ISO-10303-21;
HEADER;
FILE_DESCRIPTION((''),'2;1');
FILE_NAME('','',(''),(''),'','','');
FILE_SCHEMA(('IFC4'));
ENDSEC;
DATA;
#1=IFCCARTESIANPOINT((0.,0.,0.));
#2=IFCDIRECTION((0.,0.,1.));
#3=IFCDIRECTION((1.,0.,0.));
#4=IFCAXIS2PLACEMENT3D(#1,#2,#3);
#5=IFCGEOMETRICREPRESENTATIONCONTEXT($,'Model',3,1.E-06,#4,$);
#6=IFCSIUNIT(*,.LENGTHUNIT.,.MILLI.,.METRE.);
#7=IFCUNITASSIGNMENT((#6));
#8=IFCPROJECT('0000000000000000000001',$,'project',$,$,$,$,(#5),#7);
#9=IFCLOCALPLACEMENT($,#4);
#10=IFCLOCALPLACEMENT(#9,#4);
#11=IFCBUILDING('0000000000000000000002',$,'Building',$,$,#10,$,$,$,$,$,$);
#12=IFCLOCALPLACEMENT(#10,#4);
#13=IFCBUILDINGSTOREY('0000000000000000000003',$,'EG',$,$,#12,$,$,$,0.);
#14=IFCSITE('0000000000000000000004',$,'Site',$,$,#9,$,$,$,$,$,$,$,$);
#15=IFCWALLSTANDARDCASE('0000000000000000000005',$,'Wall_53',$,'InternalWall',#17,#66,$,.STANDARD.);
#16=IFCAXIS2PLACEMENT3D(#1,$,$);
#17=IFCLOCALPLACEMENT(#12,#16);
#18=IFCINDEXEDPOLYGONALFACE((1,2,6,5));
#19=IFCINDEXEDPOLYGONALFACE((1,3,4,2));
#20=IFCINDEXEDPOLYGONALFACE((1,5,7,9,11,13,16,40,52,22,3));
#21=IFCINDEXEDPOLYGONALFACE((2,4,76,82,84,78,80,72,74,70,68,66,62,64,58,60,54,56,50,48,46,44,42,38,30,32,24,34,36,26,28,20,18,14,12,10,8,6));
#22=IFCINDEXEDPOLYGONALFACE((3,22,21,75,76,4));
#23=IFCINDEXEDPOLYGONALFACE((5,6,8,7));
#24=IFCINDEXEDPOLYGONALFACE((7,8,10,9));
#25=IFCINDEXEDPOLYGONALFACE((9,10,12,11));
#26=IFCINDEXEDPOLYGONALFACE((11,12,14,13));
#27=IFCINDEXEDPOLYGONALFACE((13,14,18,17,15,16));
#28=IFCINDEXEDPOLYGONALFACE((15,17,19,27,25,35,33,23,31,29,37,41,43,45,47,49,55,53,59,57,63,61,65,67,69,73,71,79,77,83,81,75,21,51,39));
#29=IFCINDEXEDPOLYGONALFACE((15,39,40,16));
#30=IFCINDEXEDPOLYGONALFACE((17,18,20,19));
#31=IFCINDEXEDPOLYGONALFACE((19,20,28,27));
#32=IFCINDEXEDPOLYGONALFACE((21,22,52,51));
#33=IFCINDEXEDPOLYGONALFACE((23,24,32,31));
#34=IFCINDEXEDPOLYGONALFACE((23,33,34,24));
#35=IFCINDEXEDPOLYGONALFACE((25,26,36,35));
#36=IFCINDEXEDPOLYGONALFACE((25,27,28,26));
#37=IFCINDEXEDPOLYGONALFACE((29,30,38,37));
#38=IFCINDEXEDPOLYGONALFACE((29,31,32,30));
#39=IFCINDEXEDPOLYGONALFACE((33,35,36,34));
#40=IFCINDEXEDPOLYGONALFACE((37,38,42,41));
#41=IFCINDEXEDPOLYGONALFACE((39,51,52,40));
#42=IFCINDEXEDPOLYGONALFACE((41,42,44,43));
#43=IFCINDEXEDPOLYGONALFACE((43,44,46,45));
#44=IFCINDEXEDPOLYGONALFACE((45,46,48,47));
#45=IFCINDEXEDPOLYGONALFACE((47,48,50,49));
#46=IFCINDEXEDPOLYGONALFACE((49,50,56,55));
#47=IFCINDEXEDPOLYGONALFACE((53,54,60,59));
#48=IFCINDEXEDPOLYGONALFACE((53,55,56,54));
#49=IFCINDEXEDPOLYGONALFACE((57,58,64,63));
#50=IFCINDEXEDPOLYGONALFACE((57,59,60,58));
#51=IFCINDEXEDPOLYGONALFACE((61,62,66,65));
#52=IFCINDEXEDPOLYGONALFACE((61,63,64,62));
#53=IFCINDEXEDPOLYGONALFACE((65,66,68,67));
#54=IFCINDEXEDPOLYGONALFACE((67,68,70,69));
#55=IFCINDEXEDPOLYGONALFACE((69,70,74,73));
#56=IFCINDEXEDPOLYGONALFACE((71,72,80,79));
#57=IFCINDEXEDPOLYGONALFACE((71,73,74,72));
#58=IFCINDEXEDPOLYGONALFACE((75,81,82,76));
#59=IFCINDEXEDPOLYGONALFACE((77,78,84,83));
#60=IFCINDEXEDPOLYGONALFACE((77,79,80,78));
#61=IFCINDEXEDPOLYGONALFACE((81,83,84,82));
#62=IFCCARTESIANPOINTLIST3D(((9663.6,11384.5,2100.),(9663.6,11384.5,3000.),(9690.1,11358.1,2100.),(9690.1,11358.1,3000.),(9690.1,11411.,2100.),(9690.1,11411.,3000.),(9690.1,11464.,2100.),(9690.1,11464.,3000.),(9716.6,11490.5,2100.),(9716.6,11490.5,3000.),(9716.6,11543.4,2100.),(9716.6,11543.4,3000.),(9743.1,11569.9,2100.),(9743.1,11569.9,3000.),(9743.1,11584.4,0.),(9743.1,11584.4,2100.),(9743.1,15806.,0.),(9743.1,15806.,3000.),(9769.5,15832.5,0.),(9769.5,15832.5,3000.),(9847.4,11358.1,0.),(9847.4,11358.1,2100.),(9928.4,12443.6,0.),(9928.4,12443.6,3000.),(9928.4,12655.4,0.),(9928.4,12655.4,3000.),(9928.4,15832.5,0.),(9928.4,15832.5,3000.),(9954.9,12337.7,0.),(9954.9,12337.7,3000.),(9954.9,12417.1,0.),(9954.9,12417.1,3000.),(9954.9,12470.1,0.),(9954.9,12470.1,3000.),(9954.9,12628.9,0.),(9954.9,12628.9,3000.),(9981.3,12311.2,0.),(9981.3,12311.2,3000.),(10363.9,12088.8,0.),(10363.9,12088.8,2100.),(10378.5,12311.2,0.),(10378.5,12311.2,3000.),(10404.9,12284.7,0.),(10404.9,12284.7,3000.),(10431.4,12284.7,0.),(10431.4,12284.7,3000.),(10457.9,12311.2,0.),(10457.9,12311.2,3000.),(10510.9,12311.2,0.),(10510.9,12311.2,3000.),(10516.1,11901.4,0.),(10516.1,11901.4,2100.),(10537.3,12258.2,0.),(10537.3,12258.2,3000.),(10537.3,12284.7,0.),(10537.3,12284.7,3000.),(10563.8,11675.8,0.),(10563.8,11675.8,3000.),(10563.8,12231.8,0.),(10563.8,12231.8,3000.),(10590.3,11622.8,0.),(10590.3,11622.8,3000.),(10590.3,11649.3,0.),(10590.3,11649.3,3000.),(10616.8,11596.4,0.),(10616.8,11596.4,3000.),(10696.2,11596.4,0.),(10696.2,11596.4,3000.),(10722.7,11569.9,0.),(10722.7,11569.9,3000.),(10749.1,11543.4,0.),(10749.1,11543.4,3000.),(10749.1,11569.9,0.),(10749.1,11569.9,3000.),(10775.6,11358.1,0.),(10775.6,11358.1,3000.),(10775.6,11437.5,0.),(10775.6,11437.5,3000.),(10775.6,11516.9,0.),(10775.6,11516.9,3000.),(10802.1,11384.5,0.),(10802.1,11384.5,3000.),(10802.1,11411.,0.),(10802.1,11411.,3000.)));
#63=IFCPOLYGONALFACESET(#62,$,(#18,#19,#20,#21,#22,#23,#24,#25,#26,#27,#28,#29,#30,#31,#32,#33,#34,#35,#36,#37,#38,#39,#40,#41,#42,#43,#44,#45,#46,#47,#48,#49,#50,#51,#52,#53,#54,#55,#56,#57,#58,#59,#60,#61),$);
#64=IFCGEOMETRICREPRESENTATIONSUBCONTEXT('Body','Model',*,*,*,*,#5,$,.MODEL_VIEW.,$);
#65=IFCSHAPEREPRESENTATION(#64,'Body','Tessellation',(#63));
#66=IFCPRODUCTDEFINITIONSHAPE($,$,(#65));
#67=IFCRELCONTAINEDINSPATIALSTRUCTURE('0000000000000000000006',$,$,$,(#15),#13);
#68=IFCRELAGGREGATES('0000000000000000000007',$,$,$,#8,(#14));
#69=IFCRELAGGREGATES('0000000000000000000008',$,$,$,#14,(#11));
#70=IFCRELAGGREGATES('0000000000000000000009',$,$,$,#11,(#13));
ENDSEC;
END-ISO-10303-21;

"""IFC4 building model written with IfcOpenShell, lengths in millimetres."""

from ifc_helpers import new_model, si_unit, frame, origin_with_axes, place, context, subcontext, project, spatial, polyline, rectangle, outline, extrude, element, save


model = new_model("IFC4")

# Units and contexts
model_context = context("Model", 3, precision=1e-06, world=origin_with_axes())
body_context = subcontext(model_context, "Body", "Model", "MODEL_VIEW")
ifc_project = project(units=[si_unit("LENGTHUNIT", "METRE", prefix="MILLI")], contexts=[model_context])

# Site, building, storey
site_placement = place(None, origin_with_axes())
site = spatial("IfcSite", under=ifc_project, at=site_placement, Name="Site")
building_placement = place(site_placement, origin_with_axes())
building = spatial("IfcBuilding", under=site, at=building_placement, Name="Building")
storey_placement = place(building_placement, origin_with_axes())
storey = spatial("IfcBuildingStorey", under=building, at=storey_placement, Name="EG", Elevation=0.0)

# Wall, opening
wall_1_placement = place(storey_placement, origin_with_axes())
wall_1 = element("IfcWallStandardCase", 1, at=wall_1_placement, inside=storey, Name="Wall_53", ObjectType="InternalWall", PredefinedType="STANDARD", context=body_context, shape_type="SweptSolid", body=[
    extrude(outline(polyline([(9690.1, 11358.1, 0.0), (9663.6, 11384.5, 0.0), (9690.1, 11411.0, 0.0), (9690.1, 11464.0, 0.0), (9716.6, 11490.5, 0.0), (9716.6, 11543.4, 0.0), (9743.1, 11569.9, 0.0), (9743.1, 15806.0, 0.0), (9769.5, 15832.5, 0.0), (9928.4, 15832.5, 0.0), (9928.4, 12655.4, 0.0), (9954.9, 12628.9, 0.0), (9954.9, 12470.1, 0.0), (9928.4, 12443.6, 0.0), (9954.9, 12417.1, 0.0), (9954.9, 12337.7, 0.0), (9981.3, 12311.2, 0.0), (10378.5, 12311.2, 0.0), (10404.9, 12284.7, 0.0), (10431.4, 12284.7, 0.0), (10457.9, 12311.2, 0.0), (10510.9, 12311.2, 0.0), (10537.3, 12284.7, 0.0), (10537.3, 12258.2, 0.0), (10563.8, 12231.8, 0.0), (10563.8, 11675.8, 0.0), (10590.3, 11649.3, 0.0), (10590.3, 11622.8, 0.0), (10616.8, 11596.4, 0.0), (10696.2, 11596.4, 0.0), (10722.7, 11569.9, 0.0), (10749.1, 11569.9, 0.0), (10749.1, 11543.4, 0.0), (10775.6, 11516.9, 0.0), (10775.6, 11437.5, 0.0), (10802.1, 11411.0, 0.0), (10802.1, 11384.5, 0.0), (10775.6, 11358.1, 0.0), (9690.1, 11358.1, 0.0)])), origin_with_axes(), (0.0, 0.0, 1.0), 3000.0),
])
opening_1_placement = place(wall_1_placement, origin_with_axes())
element("IfcOpeningElement", 2, at=opening_1_placement, inside=storey, cuts=wall_1, context=body_context, shape_type="SweptSolid", body=[
    extrude(rectangle(XDim=1342.1, YDim=241.4), frame((9919.2, 11572.0, 0.0), z_axis=(0.0, 0.0, 1.0), x_axis=(-0.776114, -0.630593, 0.0)), (0.0, 0.0, 1.0), 2100.0),
])

save(model, "model.ifc")
